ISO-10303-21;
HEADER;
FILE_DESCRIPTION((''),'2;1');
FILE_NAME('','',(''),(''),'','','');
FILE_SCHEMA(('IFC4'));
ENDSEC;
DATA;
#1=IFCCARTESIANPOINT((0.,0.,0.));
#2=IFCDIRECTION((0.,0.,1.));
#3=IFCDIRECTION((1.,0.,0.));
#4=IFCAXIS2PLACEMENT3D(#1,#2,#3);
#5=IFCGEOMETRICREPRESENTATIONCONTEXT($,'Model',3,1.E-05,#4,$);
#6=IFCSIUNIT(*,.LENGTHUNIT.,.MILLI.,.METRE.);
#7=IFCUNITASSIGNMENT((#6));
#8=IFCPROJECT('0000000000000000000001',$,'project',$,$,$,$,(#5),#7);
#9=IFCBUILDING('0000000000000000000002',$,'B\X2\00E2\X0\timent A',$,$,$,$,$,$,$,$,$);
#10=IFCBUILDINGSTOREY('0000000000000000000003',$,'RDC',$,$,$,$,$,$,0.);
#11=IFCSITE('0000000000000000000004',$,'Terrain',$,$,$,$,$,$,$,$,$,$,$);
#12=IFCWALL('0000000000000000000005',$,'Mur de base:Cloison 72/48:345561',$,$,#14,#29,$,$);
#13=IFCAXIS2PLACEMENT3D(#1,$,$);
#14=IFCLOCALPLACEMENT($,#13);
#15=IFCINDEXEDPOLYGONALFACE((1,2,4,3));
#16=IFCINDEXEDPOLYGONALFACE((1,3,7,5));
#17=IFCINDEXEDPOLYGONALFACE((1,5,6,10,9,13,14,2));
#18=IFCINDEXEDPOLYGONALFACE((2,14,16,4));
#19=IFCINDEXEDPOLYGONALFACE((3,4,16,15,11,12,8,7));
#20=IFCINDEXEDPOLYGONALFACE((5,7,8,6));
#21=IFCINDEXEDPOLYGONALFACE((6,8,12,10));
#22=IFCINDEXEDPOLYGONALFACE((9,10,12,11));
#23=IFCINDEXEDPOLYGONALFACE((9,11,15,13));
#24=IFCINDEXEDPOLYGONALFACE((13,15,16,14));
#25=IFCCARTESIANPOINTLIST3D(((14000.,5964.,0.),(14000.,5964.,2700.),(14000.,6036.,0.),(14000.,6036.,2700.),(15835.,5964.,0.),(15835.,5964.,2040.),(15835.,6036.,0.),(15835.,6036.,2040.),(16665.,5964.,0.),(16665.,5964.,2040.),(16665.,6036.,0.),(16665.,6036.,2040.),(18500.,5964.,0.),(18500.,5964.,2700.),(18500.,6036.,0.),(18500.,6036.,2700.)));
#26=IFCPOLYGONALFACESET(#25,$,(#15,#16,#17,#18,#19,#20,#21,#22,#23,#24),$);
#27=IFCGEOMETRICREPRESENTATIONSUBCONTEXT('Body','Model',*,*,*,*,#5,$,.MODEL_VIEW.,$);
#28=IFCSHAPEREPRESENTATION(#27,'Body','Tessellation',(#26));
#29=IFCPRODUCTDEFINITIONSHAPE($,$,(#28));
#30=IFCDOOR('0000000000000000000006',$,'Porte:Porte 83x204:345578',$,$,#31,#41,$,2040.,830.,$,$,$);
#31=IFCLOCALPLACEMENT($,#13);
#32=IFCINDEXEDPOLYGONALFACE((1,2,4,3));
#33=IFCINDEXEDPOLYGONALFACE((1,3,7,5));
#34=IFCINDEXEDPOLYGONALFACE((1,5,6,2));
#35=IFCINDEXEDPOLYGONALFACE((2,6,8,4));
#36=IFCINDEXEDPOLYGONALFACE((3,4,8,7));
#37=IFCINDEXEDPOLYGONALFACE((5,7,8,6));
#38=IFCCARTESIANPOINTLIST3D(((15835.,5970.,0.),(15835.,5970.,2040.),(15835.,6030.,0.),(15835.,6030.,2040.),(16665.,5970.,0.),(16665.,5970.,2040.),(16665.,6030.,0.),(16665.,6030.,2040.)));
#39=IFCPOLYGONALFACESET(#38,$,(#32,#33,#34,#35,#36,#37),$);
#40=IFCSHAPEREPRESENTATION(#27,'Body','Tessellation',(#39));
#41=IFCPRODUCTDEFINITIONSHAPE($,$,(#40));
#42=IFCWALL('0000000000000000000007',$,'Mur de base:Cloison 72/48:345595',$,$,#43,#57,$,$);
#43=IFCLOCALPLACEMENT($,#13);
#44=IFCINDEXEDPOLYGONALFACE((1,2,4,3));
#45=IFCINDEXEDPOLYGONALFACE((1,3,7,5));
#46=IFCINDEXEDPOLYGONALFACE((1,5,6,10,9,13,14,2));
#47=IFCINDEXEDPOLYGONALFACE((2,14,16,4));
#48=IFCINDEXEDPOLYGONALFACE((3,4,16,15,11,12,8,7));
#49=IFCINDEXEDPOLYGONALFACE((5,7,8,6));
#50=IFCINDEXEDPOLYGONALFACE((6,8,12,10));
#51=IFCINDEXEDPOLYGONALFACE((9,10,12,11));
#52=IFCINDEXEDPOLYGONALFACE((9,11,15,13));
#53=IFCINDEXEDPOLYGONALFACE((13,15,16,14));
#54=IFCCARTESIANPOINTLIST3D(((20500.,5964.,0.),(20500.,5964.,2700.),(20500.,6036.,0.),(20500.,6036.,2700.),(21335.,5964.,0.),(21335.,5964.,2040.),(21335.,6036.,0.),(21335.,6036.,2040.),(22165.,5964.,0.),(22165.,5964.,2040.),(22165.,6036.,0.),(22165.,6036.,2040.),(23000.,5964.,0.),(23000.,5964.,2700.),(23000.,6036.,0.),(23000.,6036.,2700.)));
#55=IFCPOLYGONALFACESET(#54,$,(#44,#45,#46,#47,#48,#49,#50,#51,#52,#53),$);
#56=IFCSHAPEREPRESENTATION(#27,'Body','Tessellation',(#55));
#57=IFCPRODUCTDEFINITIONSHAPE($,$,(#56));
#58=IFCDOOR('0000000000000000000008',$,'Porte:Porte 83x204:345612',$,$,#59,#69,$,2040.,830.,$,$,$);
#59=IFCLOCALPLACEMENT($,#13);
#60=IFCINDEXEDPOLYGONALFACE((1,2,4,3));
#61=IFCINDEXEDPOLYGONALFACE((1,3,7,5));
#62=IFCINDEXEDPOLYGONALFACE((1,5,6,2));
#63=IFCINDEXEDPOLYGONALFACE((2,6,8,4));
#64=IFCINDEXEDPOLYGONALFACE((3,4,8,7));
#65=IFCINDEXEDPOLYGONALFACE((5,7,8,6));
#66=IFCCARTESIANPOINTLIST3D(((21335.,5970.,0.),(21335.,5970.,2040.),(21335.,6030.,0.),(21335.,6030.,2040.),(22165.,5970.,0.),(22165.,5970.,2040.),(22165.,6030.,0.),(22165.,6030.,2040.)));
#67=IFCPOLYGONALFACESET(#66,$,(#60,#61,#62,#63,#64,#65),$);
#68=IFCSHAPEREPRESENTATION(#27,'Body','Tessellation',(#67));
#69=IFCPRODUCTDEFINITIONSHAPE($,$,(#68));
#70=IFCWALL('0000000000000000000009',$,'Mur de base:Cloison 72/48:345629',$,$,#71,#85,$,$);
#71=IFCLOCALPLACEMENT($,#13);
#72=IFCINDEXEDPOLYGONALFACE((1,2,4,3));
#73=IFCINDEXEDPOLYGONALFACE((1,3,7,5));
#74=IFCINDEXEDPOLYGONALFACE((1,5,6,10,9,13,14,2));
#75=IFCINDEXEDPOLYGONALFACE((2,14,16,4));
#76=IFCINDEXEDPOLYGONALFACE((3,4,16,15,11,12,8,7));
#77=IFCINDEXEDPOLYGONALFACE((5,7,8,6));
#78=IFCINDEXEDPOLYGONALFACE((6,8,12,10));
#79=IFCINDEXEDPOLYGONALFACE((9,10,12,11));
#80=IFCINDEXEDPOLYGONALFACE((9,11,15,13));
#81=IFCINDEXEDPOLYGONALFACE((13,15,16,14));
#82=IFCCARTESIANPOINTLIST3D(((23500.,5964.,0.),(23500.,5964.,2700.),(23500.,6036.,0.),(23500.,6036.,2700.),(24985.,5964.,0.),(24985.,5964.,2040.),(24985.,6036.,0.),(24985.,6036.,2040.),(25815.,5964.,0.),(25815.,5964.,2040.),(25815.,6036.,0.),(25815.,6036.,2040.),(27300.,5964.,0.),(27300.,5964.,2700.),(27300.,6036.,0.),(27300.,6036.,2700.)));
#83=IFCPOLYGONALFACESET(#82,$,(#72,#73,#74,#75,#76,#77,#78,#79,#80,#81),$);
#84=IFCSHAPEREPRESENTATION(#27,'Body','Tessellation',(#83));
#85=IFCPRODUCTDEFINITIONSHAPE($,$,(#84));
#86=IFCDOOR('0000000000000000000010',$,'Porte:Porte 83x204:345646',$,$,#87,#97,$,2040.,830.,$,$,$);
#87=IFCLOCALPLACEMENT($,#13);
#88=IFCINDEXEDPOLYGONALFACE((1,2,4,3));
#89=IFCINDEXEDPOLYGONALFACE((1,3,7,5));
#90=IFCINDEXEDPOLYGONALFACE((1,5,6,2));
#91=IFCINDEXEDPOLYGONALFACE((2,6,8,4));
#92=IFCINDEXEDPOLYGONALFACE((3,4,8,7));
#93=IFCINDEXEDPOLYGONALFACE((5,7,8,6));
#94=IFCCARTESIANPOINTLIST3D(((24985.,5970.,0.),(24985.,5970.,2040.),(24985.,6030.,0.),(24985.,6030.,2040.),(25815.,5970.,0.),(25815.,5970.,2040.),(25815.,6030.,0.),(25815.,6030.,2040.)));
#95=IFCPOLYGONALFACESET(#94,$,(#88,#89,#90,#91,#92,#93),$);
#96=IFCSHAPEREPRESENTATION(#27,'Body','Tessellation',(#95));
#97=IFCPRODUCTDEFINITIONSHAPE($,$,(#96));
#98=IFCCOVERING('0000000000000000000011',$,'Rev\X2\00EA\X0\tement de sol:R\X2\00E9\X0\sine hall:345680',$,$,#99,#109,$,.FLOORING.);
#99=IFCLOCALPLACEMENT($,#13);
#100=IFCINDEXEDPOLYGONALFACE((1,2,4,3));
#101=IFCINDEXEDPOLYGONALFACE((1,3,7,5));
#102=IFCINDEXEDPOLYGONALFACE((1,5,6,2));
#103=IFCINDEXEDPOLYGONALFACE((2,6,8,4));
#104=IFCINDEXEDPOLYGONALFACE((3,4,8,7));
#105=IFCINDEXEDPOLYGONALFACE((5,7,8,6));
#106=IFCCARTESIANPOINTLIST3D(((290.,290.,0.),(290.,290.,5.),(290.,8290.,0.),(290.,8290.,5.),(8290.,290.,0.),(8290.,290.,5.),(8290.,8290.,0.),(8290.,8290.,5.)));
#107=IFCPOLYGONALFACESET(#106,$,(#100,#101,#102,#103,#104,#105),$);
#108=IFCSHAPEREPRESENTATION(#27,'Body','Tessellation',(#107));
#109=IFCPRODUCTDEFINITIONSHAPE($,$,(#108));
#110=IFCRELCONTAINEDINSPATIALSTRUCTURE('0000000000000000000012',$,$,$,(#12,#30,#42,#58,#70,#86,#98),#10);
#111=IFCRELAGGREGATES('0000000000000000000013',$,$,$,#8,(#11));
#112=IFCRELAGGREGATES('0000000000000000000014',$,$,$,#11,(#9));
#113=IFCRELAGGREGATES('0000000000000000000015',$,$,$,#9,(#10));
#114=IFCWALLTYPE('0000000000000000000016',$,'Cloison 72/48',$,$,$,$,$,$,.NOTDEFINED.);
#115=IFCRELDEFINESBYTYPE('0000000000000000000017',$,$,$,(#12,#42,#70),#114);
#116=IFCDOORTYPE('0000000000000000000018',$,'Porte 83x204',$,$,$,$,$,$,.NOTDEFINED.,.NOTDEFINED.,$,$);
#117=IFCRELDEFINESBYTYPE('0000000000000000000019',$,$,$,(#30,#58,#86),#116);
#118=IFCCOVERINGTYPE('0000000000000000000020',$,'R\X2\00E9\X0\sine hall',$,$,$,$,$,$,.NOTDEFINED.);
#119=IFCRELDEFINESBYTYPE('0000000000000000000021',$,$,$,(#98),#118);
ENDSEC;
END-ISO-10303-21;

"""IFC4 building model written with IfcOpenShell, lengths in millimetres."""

from ifc_helpers import new_model, si_unit, frame_2d, origin_with_axes, place, context, subcontext, project, spatial, rectangle, extrude, type_object, element, fill, save


model = new_model("IFC4")

# Units and contexts
model_context = context("Model", 3, precision=1e-05, world=origin_with_axes())
body_context = subcontext(model_context, "Body", "Model", "MODEL_VIEW")
ifc_project = project(units=[si_unit("LENGTHUNIT", "METRE", prefix="MILLI")], contexts=[model_context])

# Site, building, storey
site = spatial("IfcSite", under=ifc_project, Name="Terrain")
building = spatial("IfcBuilding", under=site, Name="Bâtiment A")
storey = spatial("IfcBuildingStorey", under=building, Name="RDC", Elevation=0.0)

# Walls, openings, doors
door_type = type_object("IfcDoorType", Name="Porte 83x204", OperationType="NOTDEFINED", PredefinedType="NOTDEFINED")
wall_type_1 = type_object("IfcWallType", Name="Cloison 72/48", PredefinedType="NOTDEFINED")
wall_1_placement = place(None, origin_with_axes())
wall_1 = element("IfcWall", 1, at=wall_1_placement, inside=storey, type_object=wall_type_1, Name="Mur de base:Cloison 72/48:345561", context=body_context, shape_type="SweptSolid", body=[
    extrude(rectangle(XDim=4500.0, YDim=72.0, at=frame_2d((16250.0, 6000.0))), origin_with_axes(), (0.0, 0.0, 1.0), 2700.0),
])
opening_1_placement = place(None, origin_with_axes())
opening_1 = element("IfcOpeningElement", 2, at=opening_1_placement, cuts=wall_1, context=body_context, shape_type="SweptSolid", body=[
    extrude(rectangle(XDim=830.0, YDim=192.0, at=frame_2d((16250.0, 6000.0))), origin_with_axes(), (0.0, 0.0, 1.0), 2040.0),
])
door_1_placement = place(None, origin_with_axes())
door_1 = element("IfcDoor", 3, at=door_1_placement, inside=storey, type_object=door_type, Name="Porte:Porte 83x204:345578", OverallHeight=2040.0, OverallWidth=830.0, context=body_context, shape_type="SweptSolid", body=[
    extrude(rectangle(XDim=830.0, YDim=60.0, at=frame_2d((16250.0, 6000.0))), origin_with_axes(), (0.0, 0.0, 1.0), 2040.0),
])
fill(opening_1, door_1)
wall_2_placement = place(None, origin_with_axes())
wall_2 = element("IfcWall", 4, at=wall_2_placement, inside=storey, type_object=wall_type_1, Name="Mur de base:Cloison 72/48:345595", context=body_context, shape_type="SweptSolid", body=[
    extrude(rectangle(XDim=2500.0, YDim=72.0, at=frame_2d((21750.0, 6000.0))), origin_with_axes(), (0.0, 0.0, 1.0), 2700.0),
])
opening_2_placement = place(None, origin_with_axes())
opening_2 = element("IfcOpeningElement", 5, at=opening_2_placement, cuts=wall_2, context=body_context, shape_type="SweptSolid", body=[
    extrude(rectangle(XDim=830.0, YDim=192.0, at=frame_2d((21750.0, 6000.0))), origin_with_axes(), (0.0, 0.0, 1.0), 2040.0),
])
door_2_placement = place(None, origin_with_axes())
door_2 = element("IfcDoor", 6, at=door_2_placement, inside=storey, type_object=door_type, Name="Porte:Porte 83x204:345612", OverallHeight=2040.0, OverallWidth=830.0, context=body_context, shape_type="SweptSolid", body=[
    extrude(rectangle(XDim=830.0, YDim=60.0, at=frame_2d((21750.0, 6000.0))), origin_with_axes(), (0.0, 0.0, 1.0), 2040.0),
])
fill(opening_2, door_2)
wall_3_placement = place(None, origin_with_axes())
wall_3 = element("IfcWall", 7, at=wall_3_placement, inside=storey, type_object=wall_type_1, Name="Mur de base:Cloison 72/48:345629", context=body_context, shape_type="SweptSolid", body=[
    extrude(rectangle(XDim=3800.0, YDim=72.0, at=frame_2d((25400.0, 6000.0))), origin_with_axes(), (0.0, 0.0, 1.0), 2700.0),
])
opening_3_placement = place(None, origin_with_axes())
opening_3 = element("IfcOpeningElement", 8, at=opening_3_placement, cuts=wall_3, context=body_context, shape_type="SweptSolid", body=[
    extrude(rectangle(XDim=830.0, YDim=192.0, at=frame_2d((25400.0, 6000.0))), origin_with_axes(), (0.0, 0.0, 1.0), 2040.0),
])
door_3_placement = place(None, origin_with_axes())
door_3 = element("IfcDoor", 9, at=door_3_placement, inside=storey, type_object=door_type, Name="Porte:Porte 83x204:345646", OverallHeight=2040.0, OverallWidth=830.0, context=body_context, shape_type="SweptSolid", body=[
    extrude(rectangle(XDim=830.0, YDim=60.0, at=frame_2d((25400.0, 6000.0))), origin_with_axes(), (0.0, 0.0, 1.0), 2040.0),
])
fill(opening_3, door_3)

# Covering
covering_type = type_object("IfcCoveringType", Name="Résine hall", PredefinedType="NOTDEFINED")
covering_placement = place(None, origin_with_axes())
element("IfcCovering", 10, at=covering_placement, inside=storey, type_object=covering_type, Name="Revêtement de sol:Résine hall:345680", PredefinedType="FLOORING", context=body_context, shape_type="SweptSolid", body=[
    extrude(rectangle(XDim=8000.0, YDim=8000.0, at=frame_2d((4290.0, 4290.0))), origin_with_axes(), (0.0, 0.0, 1.0), 5.0),
])

save(model, "model.ifc")
